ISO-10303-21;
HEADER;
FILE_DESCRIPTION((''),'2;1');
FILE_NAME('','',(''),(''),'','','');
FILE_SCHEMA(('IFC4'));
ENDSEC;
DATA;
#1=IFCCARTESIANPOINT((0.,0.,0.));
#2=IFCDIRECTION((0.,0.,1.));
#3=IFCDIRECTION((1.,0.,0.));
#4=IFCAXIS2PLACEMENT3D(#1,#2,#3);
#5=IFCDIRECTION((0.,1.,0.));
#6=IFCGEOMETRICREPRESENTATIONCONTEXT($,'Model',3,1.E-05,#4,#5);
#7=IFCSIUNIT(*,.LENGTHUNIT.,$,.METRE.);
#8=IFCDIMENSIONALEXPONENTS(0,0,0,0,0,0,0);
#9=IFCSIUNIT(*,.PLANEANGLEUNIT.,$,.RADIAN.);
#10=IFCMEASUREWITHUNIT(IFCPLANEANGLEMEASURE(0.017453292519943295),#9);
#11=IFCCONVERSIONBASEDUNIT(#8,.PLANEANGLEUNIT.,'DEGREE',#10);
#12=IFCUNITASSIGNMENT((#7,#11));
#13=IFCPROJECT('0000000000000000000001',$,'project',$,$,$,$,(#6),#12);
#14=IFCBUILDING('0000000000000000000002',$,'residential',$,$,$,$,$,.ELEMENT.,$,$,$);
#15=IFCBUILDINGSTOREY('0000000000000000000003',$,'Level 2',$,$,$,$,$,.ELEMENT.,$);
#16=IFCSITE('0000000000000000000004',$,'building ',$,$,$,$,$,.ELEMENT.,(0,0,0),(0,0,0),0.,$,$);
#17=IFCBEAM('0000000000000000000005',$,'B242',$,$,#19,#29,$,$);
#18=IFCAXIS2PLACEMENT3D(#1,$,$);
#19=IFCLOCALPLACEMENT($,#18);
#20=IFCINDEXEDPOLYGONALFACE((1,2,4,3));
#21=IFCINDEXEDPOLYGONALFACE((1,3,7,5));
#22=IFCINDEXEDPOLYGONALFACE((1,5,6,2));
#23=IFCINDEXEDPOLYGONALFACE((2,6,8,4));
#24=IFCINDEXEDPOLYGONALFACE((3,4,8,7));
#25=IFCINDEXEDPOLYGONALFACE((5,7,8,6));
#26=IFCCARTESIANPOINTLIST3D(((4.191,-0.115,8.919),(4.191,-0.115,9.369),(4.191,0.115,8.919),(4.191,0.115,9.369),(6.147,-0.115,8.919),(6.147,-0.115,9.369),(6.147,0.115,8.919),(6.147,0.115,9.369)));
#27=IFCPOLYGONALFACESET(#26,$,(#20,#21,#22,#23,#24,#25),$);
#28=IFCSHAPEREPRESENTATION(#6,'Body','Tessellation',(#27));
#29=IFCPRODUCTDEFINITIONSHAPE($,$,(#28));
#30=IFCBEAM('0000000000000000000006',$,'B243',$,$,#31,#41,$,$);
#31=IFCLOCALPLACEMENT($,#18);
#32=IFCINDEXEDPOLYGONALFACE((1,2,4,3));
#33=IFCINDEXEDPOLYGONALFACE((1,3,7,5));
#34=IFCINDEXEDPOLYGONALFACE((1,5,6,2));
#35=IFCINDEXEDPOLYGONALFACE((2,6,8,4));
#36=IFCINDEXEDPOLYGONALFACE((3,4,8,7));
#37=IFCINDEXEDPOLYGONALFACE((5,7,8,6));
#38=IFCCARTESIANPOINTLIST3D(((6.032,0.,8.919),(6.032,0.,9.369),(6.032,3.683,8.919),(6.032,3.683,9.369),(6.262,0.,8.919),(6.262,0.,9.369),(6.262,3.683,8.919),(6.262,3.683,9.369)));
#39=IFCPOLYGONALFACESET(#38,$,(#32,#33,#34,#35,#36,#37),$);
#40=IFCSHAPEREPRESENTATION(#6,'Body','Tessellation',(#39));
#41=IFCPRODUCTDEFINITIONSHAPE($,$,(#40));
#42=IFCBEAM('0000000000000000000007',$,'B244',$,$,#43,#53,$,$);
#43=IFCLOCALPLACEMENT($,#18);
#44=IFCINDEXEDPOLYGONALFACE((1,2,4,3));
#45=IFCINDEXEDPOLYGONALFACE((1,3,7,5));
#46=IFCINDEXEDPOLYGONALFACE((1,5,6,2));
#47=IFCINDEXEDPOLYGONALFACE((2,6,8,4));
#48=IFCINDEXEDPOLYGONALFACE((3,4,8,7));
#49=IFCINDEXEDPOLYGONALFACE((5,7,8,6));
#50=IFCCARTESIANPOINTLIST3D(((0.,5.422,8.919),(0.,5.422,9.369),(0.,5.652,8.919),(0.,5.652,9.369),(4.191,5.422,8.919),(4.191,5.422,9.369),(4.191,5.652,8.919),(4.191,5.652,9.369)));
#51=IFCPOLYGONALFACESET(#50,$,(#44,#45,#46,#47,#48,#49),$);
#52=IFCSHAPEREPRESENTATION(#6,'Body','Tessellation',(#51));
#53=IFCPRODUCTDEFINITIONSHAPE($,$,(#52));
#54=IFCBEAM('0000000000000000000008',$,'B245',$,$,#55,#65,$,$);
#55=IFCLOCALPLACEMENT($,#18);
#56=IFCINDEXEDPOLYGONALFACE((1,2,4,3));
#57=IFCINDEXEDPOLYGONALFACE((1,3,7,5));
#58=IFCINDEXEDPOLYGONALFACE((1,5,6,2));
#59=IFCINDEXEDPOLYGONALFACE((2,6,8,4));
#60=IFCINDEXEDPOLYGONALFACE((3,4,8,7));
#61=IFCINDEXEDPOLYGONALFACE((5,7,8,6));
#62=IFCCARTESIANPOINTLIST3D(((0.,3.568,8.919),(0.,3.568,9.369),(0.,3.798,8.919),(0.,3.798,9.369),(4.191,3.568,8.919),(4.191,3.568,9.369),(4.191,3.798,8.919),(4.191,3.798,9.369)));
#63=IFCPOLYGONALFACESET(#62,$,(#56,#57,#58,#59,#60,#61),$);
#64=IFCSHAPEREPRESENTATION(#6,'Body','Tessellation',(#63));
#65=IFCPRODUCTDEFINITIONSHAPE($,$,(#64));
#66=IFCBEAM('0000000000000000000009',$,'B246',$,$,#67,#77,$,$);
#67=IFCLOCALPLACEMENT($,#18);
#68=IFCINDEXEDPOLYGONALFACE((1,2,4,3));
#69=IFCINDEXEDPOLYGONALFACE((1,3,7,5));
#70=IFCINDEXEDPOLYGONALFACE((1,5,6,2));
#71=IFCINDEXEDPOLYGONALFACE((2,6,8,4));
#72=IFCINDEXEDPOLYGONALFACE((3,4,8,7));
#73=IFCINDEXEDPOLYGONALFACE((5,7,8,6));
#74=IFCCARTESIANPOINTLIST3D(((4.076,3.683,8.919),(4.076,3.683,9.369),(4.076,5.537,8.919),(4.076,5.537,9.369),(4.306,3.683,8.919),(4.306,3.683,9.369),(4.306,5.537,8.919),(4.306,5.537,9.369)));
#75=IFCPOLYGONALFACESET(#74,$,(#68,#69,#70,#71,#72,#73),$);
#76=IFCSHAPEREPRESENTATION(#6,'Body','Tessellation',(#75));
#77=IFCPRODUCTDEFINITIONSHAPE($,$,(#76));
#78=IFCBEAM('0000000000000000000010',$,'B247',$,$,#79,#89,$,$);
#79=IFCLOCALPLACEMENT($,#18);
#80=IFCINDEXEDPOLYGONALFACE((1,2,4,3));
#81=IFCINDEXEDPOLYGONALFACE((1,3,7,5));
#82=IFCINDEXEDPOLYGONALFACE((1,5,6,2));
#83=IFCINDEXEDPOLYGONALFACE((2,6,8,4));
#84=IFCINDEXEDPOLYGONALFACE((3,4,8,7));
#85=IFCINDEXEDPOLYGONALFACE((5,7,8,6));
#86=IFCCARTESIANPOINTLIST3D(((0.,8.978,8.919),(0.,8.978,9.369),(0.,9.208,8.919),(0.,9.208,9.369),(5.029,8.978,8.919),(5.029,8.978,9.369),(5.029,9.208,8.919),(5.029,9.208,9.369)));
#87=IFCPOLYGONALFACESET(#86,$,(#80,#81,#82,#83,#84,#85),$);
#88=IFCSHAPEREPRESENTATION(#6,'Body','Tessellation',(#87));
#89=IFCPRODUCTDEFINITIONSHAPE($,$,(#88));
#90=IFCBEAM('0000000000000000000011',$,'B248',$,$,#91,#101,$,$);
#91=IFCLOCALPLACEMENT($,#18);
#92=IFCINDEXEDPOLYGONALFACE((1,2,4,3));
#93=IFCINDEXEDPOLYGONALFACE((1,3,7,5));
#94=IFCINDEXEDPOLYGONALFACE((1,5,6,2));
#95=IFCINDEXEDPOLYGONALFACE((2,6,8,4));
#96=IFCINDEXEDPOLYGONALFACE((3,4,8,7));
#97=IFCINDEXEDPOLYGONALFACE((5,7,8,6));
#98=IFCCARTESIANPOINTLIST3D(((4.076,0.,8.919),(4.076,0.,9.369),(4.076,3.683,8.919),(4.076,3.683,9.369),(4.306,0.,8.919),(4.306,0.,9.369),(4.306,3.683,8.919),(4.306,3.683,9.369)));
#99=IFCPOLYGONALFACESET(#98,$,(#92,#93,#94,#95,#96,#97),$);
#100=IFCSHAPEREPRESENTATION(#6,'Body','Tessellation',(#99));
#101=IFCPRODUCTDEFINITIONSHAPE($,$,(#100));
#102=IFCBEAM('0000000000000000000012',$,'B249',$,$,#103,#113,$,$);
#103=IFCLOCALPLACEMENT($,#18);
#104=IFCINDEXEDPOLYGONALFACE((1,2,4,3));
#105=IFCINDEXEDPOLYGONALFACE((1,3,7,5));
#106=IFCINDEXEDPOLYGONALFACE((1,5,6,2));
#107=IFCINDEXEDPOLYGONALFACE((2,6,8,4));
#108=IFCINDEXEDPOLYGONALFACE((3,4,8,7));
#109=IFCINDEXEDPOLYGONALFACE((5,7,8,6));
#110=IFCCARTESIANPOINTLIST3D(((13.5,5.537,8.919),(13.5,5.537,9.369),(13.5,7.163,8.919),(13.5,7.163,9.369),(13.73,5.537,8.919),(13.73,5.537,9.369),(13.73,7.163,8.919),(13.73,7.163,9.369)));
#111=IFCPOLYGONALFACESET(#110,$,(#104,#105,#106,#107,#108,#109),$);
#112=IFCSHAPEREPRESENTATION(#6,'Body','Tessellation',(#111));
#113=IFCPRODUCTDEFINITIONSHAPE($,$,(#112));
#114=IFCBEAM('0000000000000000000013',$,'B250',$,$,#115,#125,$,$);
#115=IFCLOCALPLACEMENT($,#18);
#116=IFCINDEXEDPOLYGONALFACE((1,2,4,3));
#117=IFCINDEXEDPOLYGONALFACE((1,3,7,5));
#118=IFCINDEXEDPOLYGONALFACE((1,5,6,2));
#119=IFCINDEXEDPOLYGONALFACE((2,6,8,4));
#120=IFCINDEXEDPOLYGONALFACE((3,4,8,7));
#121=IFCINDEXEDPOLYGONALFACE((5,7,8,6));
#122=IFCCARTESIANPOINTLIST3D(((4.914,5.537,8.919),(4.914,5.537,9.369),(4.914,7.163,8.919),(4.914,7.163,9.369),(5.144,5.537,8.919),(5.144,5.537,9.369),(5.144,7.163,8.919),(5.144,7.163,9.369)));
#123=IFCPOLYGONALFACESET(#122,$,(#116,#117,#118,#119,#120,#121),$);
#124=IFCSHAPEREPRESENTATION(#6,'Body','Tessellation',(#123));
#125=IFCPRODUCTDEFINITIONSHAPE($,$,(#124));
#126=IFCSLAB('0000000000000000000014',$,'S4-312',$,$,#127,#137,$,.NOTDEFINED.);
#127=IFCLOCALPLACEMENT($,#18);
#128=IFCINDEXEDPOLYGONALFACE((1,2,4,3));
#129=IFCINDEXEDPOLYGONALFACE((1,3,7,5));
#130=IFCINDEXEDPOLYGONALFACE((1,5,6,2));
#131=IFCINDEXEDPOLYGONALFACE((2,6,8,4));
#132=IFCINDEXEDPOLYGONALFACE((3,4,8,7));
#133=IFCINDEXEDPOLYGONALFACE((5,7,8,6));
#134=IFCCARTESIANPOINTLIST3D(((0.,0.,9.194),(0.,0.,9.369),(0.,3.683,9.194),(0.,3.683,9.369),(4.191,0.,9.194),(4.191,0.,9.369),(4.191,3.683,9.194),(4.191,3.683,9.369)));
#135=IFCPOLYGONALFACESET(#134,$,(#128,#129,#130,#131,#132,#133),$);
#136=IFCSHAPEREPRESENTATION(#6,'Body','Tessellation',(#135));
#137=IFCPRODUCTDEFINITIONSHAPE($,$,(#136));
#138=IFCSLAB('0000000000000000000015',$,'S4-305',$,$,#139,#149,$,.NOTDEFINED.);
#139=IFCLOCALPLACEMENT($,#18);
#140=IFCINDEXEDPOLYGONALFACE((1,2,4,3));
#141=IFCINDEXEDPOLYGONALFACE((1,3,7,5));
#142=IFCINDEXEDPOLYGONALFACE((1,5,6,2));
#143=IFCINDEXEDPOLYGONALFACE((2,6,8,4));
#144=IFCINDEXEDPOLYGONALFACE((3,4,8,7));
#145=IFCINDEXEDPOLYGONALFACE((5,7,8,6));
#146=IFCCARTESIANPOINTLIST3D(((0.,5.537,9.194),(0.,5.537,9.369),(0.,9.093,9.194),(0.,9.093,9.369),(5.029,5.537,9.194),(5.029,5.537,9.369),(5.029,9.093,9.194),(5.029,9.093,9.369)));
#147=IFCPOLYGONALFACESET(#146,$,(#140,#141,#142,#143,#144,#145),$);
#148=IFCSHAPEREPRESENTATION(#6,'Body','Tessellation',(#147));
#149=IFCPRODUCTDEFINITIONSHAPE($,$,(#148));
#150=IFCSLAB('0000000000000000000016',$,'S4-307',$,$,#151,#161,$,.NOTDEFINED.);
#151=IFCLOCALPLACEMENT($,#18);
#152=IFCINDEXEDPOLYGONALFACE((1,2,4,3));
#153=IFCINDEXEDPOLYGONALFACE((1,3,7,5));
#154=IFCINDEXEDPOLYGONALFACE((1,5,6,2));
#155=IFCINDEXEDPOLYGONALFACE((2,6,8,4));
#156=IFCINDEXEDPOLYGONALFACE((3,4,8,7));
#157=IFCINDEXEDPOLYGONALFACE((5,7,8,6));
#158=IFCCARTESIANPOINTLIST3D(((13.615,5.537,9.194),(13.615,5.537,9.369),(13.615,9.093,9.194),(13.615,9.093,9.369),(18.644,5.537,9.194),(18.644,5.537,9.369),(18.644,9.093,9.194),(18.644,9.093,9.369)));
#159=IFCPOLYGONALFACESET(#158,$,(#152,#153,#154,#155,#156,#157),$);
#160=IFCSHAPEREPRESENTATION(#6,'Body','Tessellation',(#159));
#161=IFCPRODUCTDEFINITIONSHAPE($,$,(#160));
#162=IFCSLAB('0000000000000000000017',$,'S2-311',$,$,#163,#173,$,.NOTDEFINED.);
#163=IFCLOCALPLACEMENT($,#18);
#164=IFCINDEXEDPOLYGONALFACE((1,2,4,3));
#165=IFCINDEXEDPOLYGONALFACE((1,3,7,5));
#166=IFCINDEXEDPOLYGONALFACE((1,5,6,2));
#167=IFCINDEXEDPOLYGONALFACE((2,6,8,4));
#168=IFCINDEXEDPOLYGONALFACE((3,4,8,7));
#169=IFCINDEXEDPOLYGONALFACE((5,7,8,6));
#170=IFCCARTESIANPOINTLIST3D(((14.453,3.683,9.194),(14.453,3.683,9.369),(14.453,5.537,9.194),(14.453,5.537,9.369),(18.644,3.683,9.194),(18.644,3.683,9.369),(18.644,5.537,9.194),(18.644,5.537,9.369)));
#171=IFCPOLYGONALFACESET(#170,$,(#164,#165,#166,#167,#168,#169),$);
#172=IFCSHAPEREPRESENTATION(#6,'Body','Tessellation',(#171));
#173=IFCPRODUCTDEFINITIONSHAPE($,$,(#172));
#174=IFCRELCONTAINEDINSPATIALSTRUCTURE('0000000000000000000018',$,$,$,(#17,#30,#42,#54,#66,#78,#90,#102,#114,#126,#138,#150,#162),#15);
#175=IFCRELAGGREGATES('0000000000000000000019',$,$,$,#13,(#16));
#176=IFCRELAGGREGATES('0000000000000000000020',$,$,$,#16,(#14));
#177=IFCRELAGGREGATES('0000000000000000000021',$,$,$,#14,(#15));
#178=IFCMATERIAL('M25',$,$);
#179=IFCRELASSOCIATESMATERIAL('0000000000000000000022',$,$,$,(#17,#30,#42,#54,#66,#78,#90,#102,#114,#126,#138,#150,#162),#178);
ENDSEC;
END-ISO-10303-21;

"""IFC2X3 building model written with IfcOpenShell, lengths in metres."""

from ifc_helpers import new_model, entity, si_unit, converted_unit, direction, frame, frame_2d, origin_with_axes, place, context, project, spatial, rectangle, extrude, material, element, save


model = new_model("IFC2X3")

# Units and contexts
model_context = context("Model", 3, precision=1e-05, world=origin_with_axes(), true_north=direction((0.0, 1.0, 0.0)))
ifc_project = project(units=[si_unit("LENGTHUNIT", "METRE"), converted_unit("PLANEANGLEUNIT", "DEGREE", entity("IfcPlaneAngleMeasure", 0.017453292519943295), si_unit("PLANEANGLEUNIT", "RADIAN"), dimensions=[0, 0, 0, 0, 0, 0, 0])], contexts=[model_context])

# Site, building, storey
site = spatial("IfcSite", under=ifc_project, Name="building ", CompositionType="ELEMENT", RefLatitude=(0, 0, 0), RefLongitude=(0, 0, 0), RefElevation=0.0)
building = spatial("IfcBuilding", under=site, Name="residential", CompositionType="ELEMENT")
storey = spatial("IfcBuildingStorey", under=building, Name="Level 2", CompositionType="ELEMENT")

# Beams
ifc_material = material(Name="M25")
placement = place(None, origin_with_axes())
element("IfcBeam", 1, at=placement, inside=storey, material=ifc_material, Name="B242", context=model_context, shape_type="SweptSolid", body=[
    extrude(rectangle(XDim=0.23, YDim=0.45, at=frame_2d((0.0, 0.0), x_axis=(0.0, 1.0, 0.0))), frame((4.191, 0.0, 9.144), z_axis=(1.0, 0.0, 0.0), x_axis=(0.0, 0.0, -1.0)), (0.0, 0.0, 1.0), 1.956),
])
element("IfcBeam", 2, at=placement, inside=storey, material=ifc_material, Name="B243", context=model_context, shape_type="SweptSolid", body=[
    extrude(rectangle(XDim=0.23, YDim=0.45, at=frame_2d((0.0, 0.0), x_axis=(0.0, 1.0, 0.0))), frame((6.147, 0.0, 9.144), z_axis=(0.0, 1.0, 0.0), x_axis=(0.0, 0.0, -1.0)), (0.0, 0.0, 1.0), 3.683),
])
element("IfcBeam", 3, at=placement, inside=storey, material=ifc_material, Name="B244", context=model_context, shape_type="SweptSolid", body=[
    extrude(rectangle(XDim=0.23, YDim=0.45, at=frame_2d((0.0, 0.0), x_axis=(0.0, 1.0, 0.0))), frame((0.0, 5.537, 9.144), z_axis=(1.0, 0.0, 0.0), x_axis=(0.0, 0.0, -1.0)), (0.0, 0.0, 1.0), 4.191),
])
element("IfcBeam", 4, at=placement, inside=storey, material=ifc_material, Name="B245", context=model_context, shape_type="SweptSolid", body=[
    extrude(rectangle(XDim=0.23, YDim=0.45, at=frame_2d((0.0, 0.0), x_axis=(0.0, 1.0, 0.0))), frame((0.0, 3.683, 9.144), z_axis=(1.0, 0.0, 0.0), x_axis=(0.0, 0.0, -1.0)), (0.0, 0.0, 1.0), 4.191),
])
element("IfcBeam", 5, at=placement, inside=storey, material=ifc_material, Name="B246", context=model_context, shape_type="SweptSolid", body=[
    extrude(rectangle(XDim=0.23, YDim=0.45, at=frame_2d((0.0, 0.0), x_axis=(0.0, 1.0, 0.0))), frame((4.191, 3.683, 9.144), z_axis=(0.0, 1.0, 0.0), x_axis=(0.0, 0.0, -1.0)), (0.0, 0.0, 1.0), 1.854),
])
element("IfcBeam", 6, at=placement, inside=storey, material=ifc_material, Name="B247", context=model_context, shape_type="SweptSolid", body=[
    extrude(rectangle(XDim=0.23, YDim=0.45, at=frame_2d((0.0, 0.0), x_axis=(0.0, 1.0, 0.0))), frame((0.0, 9.093, 9.144), z_axis=(1.0, 0.0, 0.0), x_axis=(0.0, 0.0, -1.0)), (0.0, 0.0, 1.0), 5.029),
])
element("IfcBeam", 7, at=placement, inside=storey, material=ifc_material, Name="B248", context=model_context, shape_type="SweptSolid", body=[
    extrude(rectangle(XDim=0.23, YDim=0.45, at=frame_2d((0.0, 0.0), x_axis=(0.0, 1.0, 0.0))), frame((4.191, 0.0, 9.144), z_axis=(0.0, 1.0, 0.0), x_axis=(0.0, 0.0, -1.0)), (0.0, 0.0, 1.0), 3.683),
])
element("IfcBeam", 8, at=placement, inside=storey, material=ifc_material, Name="B249", context=model_context, shape_type="SweptSolid", body=[
    extrude(rectangle(XDim=0.23, YDim=0.45, at=frame_2d((0.0, 0.0), x_axis=(0.0, 1.0, 0.0))), frame((13.615, 5.537, 9.144), z_axis=(0.0, 1.0, 0.0), x_axis=(0.0, 0.0, -1.0)), (0.0, 0.0, 1.0), 1.626),
])
element("IfcBeam", 9, at=placement, inside=storey, material=ifc_material, Name="B250", context=model_context, shape_type="SweptSolid", body=[
    extrude(rectangle(XDim=0.23, YDim=0.45, at=frame_2d((0.0, 0.0), x_axis=(0.0, 1.0, 0.0))), frame((5.029, 5.537, 9.144), z_axis=(0.0, 1.0, 0.0), x_axis=(0.0, 0.0, -1.0)), (0.0, 0.0, 1.0), 1.626),
])

# Slabs
element("IfcSlab", 10, at=placement, inside=storey, material=ifc_material, Name="S4-312", PredefinedType="NOTDEFINED", context=model_context, shape_type="SweptSolid", body=[
    extrude(rectangle(XDim=4.191, YDim=3.683, at=frame_2d((0.0, 0.0), x_axis=(1.0, 0.0, 0.0))), frame((2.0955, 1.8415, 9.194), z_axis=(0.0, 0.0, 1.0), x_axis=(1.0, 0.0, 0.0)), (0.0, 0.0, 1.0), 0.175),
])
element("IfcSlab", 11, at=placement, inside=storey, material=ifc_material, Name="S4-305", PredefinedType="NOTDEFINED", context=model_context, shape_type="SweptSolid", body=[
    extrude(rectangle(XDim=5.029, YDim=3.556, at=frame_2d((0.0, 0.0), x_axis=(1.0, 0.0, 0.0))), frame((2.5145, 7.315, 9.194), z_axis=(0.0, 0.0, 1.0), x_axis=(1.0, 0.0, 0.0)), (0.0, 0.0, 1.0), 0.175),
])
element("IfcSlab", 12, at=placement, inside=storey, material=ifc_material, Name="S4-307", PredefinedType="NOTDEFINED", context=model_context, shape_type="SweptSolid", body=[
    extrude(rectangle(XDim=5.029, YDim=3.556, at=frame_2d((0.0, 0.0), x_axis=(1.0, 0.0, 0.0))), frame((16.1295, 7.315, 9.194), z_axis=(0.0, 0.0, 1.0), x_axis=(1.0, 0.0, 0.0)), (0.0, 0.0, 1.0), 0.175),
])
element("IfcSlab", 13, at=placement, inside=storey, material=ifc_material, Name="S2-311", PredefinedType="NOTDEFINED", context=model_context, shape_type="SweptSolid", body=[
    extrude(rectangle(XDim=4.191, YDim=1.854, at=frame_2d((0.0, 0.0), x_axis=(1.0, 0.0, 0.0))), frame((16.5485, 4.61, 9.194), z_axis=(0.0, 0.0, 1.0), x_axis=(1.0, 0.0, 0.0)), (0.0, 0.0, 1.0), 0.175),
])

save(model, "model.ifc")
